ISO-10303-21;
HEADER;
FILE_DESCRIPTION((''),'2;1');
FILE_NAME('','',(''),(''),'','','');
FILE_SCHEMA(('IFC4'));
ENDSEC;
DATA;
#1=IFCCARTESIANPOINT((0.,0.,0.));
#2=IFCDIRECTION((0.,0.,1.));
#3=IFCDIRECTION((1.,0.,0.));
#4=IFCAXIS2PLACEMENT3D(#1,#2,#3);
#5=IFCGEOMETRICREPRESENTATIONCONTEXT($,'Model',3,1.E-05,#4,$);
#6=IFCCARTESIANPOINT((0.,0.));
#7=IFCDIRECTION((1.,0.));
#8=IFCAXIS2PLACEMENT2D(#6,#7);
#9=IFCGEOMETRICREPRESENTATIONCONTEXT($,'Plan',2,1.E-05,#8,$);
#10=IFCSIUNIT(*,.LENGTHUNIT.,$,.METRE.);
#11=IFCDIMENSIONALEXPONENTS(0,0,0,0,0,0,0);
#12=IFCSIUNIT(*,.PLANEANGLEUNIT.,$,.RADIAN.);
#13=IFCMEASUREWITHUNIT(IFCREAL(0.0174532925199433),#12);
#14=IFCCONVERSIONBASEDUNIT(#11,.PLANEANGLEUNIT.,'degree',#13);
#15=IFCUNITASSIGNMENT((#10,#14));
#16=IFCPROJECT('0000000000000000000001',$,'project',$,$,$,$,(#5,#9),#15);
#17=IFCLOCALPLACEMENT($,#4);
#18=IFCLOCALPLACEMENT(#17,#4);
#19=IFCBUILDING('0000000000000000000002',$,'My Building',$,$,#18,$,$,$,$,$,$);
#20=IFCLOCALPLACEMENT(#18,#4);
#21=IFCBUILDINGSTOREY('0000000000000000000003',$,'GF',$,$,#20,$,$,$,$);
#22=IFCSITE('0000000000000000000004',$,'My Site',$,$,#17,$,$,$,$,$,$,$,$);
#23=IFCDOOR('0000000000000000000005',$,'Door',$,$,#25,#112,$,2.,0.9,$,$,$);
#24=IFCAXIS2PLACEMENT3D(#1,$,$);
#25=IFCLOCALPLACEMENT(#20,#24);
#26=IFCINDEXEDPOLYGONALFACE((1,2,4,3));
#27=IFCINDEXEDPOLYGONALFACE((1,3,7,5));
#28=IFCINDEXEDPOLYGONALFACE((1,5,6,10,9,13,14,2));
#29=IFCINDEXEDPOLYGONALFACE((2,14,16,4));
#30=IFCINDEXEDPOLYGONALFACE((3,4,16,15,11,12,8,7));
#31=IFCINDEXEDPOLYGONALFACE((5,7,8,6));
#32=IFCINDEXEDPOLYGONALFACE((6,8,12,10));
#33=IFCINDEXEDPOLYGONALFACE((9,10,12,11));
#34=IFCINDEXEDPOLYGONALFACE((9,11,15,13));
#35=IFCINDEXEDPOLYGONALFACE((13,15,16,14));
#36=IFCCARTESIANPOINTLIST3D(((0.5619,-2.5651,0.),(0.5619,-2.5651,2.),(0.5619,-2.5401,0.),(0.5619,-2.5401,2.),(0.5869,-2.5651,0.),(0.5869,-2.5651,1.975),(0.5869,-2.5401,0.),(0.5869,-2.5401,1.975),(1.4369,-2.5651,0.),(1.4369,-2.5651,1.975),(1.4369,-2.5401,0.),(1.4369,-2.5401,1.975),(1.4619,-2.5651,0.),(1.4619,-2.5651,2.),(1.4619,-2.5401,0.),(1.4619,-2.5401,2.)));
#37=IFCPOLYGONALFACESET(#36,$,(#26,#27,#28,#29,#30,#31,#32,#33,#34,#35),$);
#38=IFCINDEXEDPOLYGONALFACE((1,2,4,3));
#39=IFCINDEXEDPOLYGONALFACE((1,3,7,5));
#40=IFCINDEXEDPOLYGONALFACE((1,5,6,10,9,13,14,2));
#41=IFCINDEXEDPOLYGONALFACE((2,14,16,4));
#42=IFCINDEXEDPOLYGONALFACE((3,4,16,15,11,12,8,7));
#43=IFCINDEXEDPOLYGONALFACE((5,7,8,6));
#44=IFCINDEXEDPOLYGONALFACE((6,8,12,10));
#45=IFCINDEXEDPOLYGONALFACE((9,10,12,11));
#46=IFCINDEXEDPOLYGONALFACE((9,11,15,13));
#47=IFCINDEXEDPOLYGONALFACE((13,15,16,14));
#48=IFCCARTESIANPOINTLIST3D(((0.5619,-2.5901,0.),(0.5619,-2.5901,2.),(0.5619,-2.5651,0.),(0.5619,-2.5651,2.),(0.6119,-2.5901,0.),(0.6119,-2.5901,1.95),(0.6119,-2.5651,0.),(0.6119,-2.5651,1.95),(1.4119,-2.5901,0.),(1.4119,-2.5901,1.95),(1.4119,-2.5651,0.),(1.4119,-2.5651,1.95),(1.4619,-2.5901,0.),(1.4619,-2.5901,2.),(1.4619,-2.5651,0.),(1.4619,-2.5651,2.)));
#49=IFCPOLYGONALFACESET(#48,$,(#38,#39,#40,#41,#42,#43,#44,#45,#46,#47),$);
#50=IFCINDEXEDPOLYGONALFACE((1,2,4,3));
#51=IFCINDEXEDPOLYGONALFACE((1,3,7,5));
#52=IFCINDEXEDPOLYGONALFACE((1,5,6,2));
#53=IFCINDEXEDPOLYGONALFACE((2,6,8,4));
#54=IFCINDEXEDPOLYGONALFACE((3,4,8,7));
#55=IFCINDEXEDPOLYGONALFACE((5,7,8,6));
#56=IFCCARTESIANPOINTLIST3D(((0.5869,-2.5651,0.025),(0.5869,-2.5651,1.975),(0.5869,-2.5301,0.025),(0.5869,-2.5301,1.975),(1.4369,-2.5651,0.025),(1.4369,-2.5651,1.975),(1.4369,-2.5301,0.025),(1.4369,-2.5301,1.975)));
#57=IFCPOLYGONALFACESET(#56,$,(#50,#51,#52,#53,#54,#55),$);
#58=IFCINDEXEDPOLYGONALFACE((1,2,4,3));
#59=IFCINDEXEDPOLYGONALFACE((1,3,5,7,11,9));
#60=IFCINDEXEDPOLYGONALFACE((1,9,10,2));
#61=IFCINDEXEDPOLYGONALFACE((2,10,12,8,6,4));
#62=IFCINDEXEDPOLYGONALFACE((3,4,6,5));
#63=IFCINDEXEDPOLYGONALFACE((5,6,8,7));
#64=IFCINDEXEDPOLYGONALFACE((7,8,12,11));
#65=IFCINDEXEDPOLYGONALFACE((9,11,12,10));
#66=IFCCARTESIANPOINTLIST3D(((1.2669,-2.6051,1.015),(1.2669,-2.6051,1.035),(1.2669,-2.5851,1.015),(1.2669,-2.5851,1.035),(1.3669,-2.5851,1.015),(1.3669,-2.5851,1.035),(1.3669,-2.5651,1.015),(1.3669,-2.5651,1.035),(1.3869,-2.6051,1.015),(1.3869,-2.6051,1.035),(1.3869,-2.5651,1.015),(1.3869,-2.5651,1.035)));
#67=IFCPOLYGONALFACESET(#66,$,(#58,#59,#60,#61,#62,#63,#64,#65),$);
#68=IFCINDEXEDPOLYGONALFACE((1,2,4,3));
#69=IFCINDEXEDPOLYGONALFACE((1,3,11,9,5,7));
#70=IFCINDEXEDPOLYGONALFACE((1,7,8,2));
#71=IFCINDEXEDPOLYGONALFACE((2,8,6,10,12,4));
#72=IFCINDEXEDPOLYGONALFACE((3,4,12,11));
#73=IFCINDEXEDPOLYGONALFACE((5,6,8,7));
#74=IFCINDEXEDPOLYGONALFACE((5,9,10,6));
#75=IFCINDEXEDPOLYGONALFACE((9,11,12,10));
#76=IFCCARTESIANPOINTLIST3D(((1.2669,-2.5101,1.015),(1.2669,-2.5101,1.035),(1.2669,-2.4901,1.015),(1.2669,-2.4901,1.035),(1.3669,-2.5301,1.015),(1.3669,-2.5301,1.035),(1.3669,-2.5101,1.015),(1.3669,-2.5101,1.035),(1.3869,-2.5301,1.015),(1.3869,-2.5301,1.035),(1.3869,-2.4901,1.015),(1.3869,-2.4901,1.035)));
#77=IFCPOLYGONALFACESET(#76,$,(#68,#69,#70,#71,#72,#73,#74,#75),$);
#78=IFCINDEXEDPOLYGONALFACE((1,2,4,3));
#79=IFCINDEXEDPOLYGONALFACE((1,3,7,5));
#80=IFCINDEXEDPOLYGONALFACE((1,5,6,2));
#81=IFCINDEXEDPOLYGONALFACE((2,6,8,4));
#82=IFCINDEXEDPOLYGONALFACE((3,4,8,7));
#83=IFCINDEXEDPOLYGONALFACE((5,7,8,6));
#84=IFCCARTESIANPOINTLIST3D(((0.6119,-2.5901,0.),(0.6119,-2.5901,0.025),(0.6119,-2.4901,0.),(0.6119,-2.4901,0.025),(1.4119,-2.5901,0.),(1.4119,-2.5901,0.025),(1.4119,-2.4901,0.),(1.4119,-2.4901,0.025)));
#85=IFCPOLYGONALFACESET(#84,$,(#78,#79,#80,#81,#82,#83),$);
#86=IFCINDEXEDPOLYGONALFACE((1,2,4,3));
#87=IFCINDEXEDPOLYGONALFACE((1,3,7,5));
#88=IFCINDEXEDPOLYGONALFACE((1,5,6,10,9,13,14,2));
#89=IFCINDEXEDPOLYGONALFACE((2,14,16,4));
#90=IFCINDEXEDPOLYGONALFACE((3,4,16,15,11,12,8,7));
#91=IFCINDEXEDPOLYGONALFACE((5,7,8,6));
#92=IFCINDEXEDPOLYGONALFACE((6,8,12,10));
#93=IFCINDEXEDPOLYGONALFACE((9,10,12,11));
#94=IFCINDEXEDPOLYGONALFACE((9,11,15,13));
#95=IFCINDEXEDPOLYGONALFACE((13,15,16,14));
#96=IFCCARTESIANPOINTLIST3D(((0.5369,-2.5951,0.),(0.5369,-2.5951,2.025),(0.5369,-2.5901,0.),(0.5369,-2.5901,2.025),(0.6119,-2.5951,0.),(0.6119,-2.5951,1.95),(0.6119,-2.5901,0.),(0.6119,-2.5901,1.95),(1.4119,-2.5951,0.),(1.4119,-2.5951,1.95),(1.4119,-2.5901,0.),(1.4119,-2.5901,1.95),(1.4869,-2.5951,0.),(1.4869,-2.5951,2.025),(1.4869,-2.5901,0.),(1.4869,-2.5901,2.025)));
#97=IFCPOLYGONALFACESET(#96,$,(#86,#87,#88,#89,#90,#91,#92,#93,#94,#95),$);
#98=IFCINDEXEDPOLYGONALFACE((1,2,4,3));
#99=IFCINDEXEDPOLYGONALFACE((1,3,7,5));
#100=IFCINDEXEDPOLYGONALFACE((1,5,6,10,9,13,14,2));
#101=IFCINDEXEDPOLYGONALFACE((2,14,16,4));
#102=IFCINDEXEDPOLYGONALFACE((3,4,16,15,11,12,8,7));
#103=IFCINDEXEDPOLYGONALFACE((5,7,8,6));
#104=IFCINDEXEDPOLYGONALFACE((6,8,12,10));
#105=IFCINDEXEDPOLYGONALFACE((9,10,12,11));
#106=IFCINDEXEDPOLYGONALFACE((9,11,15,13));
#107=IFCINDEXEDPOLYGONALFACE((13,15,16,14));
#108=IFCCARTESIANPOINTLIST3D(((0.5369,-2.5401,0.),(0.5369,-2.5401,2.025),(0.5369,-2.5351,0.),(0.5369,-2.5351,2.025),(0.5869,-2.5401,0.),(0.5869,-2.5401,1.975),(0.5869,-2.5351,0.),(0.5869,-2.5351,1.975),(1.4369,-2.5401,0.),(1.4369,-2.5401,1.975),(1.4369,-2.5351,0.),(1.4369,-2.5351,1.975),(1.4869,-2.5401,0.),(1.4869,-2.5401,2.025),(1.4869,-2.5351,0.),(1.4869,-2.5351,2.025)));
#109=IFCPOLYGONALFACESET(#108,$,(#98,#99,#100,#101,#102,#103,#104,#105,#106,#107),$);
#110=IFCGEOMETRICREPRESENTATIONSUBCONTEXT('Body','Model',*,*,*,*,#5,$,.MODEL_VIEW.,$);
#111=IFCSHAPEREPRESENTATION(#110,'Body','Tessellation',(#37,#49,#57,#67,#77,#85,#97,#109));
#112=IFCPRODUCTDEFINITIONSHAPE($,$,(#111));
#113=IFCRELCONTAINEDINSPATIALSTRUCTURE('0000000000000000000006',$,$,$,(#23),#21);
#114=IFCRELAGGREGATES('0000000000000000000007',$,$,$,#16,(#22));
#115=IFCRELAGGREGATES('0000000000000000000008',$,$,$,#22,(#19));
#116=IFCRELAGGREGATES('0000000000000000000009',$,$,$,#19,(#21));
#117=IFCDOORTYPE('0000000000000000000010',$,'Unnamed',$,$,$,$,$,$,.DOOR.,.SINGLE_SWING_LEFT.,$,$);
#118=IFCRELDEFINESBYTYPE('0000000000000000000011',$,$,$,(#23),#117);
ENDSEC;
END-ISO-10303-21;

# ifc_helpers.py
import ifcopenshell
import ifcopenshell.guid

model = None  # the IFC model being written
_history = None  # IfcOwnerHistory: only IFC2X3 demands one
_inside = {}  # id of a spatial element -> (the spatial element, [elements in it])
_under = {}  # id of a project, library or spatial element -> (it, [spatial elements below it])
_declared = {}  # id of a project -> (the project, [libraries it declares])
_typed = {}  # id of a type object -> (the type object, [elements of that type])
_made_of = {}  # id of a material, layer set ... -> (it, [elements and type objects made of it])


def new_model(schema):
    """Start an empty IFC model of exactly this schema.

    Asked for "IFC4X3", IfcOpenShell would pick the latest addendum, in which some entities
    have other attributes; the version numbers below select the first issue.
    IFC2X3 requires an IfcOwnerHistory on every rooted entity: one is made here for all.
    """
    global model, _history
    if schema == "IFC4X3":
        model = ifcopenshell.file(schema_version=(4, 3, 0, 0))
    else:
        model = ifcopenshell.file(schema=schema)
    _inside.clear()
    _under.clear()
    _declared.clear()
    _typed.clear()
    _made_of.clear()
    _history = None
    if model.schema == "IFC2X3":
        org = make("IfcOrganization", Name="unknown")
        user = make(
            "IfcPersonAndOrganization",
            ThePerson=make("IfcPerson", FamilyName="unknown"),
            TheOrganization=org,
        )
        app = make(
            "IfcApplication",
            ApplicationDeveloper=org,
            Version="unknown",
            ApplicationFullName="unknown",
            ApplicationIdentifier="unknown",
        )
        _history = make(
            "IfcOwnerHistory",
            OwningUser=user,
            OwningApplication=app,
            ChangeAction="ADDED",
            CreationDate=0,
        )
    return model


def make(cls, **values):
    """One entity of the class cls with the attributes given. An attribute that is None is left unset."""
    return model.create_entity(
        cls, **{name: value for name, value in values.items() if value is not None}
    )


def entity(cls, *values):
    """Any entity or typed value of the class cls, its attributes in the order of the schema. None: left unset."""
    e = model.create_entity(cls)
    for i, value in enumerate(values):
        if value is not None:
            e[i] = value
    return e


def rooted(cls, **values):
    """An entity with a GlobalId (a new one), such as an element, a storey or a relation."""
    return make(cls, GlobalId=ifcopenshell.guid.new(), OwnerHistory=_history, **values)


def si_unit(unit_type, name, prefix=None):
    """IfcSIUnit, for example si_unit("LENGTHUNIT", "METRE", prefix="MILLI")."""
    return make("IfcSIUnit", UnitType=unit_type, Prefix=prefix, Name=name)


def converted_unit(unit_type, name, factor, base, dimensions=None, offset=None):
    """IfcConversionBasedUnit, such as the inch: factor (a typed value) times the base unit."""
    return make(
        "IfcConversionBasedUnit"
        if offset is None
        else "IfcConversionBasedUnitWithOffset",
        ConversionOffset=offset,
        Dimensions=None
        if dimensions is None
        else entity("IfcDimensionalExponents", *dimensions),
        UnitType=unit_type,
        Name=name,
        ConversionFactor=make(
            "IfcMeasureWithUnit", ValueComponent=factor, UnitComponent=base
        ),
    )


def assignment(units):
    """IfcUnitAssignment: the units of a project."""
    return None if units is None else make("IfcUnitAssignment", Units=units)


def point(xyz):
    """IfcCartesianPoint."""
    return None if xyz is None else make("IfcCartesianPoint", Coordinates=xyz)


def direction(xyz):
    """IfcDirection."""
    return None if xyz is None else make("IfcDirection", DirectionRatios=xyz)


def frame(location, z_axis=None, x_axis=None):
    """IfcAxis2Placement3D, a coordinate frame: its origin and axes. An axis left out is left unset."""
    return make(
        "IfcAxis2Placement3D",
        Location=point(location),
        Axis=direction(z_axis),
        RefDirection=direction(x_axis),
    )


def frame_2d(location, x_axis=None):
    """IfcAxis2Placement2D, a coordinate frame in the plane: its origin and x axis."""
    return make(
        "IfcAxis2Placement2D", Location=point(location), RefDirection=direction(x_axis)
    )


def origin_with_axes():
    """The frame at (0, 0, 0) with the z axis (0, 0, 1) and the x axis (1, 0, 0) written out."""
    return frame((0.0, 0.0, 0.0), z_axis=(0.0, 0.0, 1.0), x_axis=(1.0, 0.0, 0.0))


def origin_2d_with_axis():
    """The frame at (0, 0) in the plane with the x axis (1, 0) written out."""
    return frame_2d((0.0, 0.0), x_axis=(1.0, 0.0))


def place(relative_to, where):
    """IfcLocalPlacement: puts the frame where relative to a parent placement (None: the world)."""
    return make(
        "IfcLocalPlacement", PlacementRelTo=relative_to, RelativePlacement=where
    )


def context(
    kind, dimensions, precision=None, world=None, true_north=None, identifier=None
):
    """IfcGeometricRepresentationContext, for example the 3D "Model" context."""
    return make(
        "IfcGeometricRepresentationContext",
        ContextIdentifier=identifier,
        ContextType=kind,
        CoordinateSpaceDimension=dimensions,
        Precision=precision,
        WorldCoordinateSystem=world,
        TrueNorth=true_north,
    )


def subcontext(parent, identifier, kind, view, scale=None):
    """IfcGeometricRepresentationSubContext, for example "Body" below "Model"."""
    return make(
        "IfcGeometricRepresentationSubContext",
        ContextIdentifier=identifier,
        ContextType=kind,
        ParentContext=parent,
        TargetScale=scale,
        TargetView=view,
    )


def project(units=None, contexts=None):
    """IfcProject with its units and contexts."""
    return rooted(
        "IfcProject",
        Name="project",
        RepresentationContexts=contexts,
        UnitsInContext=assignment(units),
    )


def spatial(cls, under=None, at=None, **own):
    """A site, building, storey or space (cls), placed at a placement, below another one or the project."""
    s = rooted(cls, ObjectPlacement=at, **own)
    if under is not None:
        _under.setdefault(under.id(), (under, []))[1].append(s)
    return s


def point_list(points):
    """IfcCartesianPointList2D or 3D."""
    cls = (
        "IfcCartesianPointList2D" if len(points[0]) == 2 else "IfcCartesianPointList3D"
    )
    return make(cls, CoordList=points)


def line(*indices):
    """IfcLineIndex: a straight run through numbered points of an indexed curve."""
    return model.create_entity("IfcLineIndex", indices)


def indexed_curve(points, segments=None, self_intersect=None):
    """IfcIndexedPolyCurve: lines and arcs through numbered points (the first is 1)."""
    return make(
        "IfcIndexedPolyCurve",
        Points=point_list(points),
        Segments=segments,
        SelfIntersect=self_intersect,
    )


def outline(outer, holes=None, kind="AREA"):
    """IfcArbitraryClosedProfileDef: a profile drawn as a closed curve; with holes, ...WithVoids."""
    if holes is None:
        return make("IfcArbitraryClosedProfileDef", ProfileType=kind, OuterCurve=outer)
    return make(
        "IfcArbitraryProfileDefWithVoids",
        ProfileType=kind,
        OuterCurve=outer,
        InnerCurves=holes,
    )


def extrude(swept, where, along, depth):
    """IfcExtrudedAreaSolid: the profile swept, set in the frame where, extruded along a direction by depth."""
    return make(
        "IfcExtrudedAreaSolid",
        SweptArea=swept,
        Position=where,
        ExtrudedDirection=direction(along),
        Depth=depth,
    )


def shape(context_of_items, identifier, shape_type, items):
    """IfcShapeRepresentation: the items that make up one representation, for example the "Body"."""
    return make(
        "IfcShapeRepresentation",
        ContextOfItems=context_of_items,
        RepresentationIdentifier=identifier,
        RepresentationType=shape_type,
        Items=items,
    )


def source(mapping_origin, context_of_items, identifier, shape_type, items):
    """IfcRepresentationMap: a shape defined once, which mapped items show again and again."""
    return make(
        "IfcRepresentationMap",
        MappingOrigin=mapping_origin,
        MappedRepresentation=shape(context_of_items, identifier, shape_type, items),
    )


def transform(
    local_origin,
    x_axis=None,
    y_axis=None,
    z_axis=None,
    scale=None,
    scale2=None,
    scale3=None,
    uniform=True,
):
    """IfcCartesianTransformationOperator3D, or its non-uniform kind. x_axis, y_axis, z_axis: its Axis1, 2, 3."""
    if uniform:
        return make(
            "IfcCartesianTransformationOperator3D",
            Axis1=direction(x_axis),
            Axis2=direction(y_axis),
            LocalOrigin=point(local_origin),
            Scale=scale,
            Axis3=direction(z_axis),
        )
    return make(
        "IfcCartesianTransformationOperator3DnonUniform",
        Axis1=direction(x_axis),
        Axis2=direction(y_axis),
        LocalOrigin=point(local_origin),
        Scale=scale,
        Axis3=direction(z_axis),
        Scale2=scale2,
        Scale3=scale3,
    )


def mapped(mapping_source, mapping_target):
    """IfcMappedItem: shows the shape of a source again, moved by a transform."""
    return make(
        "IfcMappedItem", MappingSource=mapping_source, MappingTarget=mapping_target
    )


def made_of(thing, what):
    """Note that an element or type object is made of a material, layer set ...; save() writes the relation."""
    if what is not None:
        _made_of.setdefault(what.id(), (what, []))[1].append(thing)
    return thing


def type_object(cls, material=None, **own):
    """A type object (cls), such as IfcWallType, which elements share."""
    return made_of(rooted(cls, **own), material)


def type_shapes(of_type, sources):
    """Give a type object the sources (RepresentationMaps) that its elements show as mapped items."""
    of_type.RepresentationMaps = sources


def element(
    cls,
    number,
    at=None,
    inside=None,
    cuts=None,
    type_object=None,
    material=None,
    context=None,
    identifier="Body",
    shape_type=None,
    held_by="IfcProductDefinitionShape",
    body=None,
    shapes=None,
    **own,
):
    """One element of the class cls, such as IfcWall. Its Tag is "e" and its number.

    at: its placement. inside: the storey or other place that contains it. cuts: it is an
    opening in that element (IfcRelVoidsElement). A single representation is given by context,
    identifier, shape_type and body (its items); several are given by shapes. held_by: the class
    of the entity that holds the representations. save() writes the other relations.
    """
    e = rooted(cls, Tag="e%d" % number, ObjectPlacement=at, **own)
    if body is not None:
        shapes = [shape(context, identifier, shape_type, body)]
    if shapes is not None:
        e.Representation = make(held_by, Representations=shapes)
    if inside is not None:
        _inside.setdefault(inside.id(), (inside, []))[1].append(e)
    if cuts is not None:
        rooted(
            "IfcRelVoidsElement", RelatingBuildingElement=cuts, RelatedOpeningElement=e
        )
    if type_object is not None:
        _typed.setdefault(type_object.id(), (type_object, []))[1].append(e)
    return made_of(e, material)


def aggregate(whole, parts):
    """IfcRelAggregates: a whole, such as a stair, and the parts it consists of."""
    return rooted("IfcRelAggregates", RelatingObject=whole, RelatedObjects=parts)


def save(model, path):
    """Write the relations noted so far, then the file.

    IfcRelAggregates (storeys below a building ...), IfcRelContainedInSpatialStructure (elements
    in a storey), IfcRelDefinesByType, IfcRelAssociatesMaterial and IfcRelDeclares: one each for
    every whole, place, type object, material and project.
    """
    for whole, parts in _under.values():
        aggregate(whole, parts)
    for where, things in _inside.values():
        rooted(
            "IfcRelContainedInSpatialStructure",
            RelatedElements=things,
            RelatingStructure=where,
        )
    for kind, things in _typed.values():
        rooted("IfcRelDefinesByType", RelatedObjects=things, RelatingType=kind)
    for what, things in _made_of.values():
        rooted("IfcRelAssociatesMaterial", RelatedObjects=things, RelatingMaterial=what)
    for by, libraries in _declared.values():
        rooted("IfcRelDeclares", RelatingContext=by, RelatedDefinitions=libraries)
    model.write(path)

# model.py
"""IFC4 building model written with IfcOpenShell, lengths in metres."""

from ifc_helpers import new_model, entity, si_unit, converted_unit, frame, origin_with_axes, origin_2d_with_axis, place, context, subcontext, project, spatial, line, indexed_curve, outline, extrude, shape, source, transform, mapped, type_object, type_shapes, element, save


model = new_model("IFC4")

# Units and contexts
model_context = context("Model", 3, precision=1e-05, world=origin_with_axes())
plan_context = context("Plan", 2, precision=1e-05, world=origin_2d_with_axis())
body_context_1 = subcontext(model_context, "Body", "Model", "MODEL_VIEW")
body_context_2 = subcontext(plan_context, "Body", "Plan", "PLAN_VIEW")
ifc_project = project(units=[si_unit("LENGTHUNIT", "METRE"), converted_unit("PLANEANGLEUNIT", "degree", entity("IfcReal", 0.0174532925199433), si_unit("PLANEANGLEUNIT", "RADIAN"), dimensions=[0, 0, 0, 0, 0, 0, 0])], contexts=[model_context, plan_context])

# Site, building, storey
site_placement = place(None, origin_with_axes())
site = spatial("IfcSite", under=ifc_project, at=site_placement, Name="My Site")
building_placement = place(site_placement, origin_with_axes())
building = spatial("IfcBuilding", under=site, at=building_placement, Name="My Building")
storey_placement = place(building_placement, origin_with_axes())
storey = spatial("IfcBuildingStorey", under=building, at=storey_placement, Name="GF")

# Shared definitions
door_type = type_object("IfcDoorType", Name="Unnamed", OperationType="SINGLE_SWING_LEFT", PredefinedType="DOOR")
shared_shape_1 = source(origin_with_axes(), body_context_1, "Body", "SweptSolid", [
    extrude(outline(indexed_curve([(0.0, 0.0), (0.0, 2.0), (0.9, 2.0), (0.9, 0.0), (0.875, 0.0), (0.875, 1.975), (0.025, 1.975), (0.025, 0.0)], segments=[line(1, 2, 3, 4, 5, 6, 7, 8, 1)])), frame((0.0, 0.025, 0.0), z_axis=(0.0, -1.0, 0.0), x_axis=(1.0, 0.0, 0.0)), (0.0, 0.0, -1.0), 0.025),
    extrude(outline(indexed_curve([(0.0, 0.0), (0.0, 2.0), (0.9, 2.0), (0.9, 0.0), (0.85, 0.0), (0.85, 1.95), (0.05, 1.95), (0.05, 0.0)], segments=[line(1, 2, 3, 4, 5, 6, 7, 8, 1)])), frame((0.0, 0.0, 0.0), z_axis=(0.0, -1.0, 0.0), x_axis=(1.0, 0.0, 0.0)), (0.0, 0.0, -1.0), 0.025),
    extrude(outline(indexed_curve([(0.0, 0.0), (0.85, 0.0), (0.85, 0.035), (0.0, 0.035)], segments=[line(1, 2, 3, 4, 1)])), frame((0.025, 0.025, 0.025), z_axis=(0.0, 0.0, 1.0), x_axis=(1.0, 0.0, 0.0)), (0.0, 0.0, 1.0), 1.95),
    extrude(outline(indexed_curve([(0.0, 0.0), (0.0, -0.04), (-0.12, -0.04), (-0.12, -0.02), (-0.02, -0.02), (-0.02, 0.0)], segments=[line(1, 2, 3, 4, 5, 6, 1)])), frame((0.825, 0.025, 1.015), z_axis=(0.0, 0.0, 1.0), x_axis=(1.0, 0.0, 0.0)), (0.0, 0.0, 1.0), 0.02),
    extrude(outline(indexed_curve([(0.0, 0.0), (0.0, 0.04), (-0.12, 0.04), (-0.12, 0.02), (-0.02, 0.02), (-0.02, 0.0)], segments=[line(1, 2, 3, 4, 5, 6, 1)])), frame((0.825, 0.06, 1.015), z_axis=(0.0, 0.0, 1.0), x_axis=(1.0, 0.0, 0.0)), (0.0, 0.0, 1.0), 0.02),
    extrude(outline(indexed_curve([(0.0, 0.0), (0.8, 0.0), (0.8, 0.1), (0.0, 0.1)], segments=[line(1, 2, 3, 4, 1)])), frame((0.05, 0.0, 0.0), z_axis=(0.0, 0.0, 1.0), x_axis=(1.0, 0.0, 0.0)), (0.0, 0.0, 1.0), 0.025),
    extrude(outline(indexed_curve([(0.0, 0.0), (0.0, 2.025), (0.95, 2.025), (0.95, 0.0), (0.875, 0.0), (0.875, 1.95), (0.075, 1.95), (0.075, 0.0)], segments=[line(1, 2, 3, 4, 5, 6, 7, 8, 1)])), frame((-0.025, -0.005, 0.0), z_axis=(0.0, -1.0, 0.0), x_axis=(1.0, 0.0, 0.0)), (0.0, 0.0, -1.0), 0.005),
    extrude(outline(indexed_curve([(0.0, 0.0), (0.0, 2.025), (0.95, 2.025), (0.95, 0.0), (0.9, 0.0), (0.9, 1.975), (0.05, 1.975), (0.05, 0.0)], segments=[line(1, 2, 3, 4, 5, 6, 7, 8, 1)])), frame((-0.025, 0.05, 0.0), z_axis=(0.0, -1.0, 0.0), x_axis=(1.0, 0.0, 0.0)), (0.0, 0.0, -1.0), 0.005),
])
shared_shape_2 = source(origin_with_axes(), body_context_2, "Body", "Curve2D", [
    entity("IfcIndexedPolyCurve", entity("IfcCartesianPointList2D", [[0.0, 0.0], [0.0, 0.05], [0.025, 0.05], [0.025, 0.025], [0.05, 0.025], [0.05, 0.0]]), [entity("IfcLineIndex", [1, 2, 3, 4, 5, 6, 1])]),
    entity("IfcIndexedPolyCurve", entity("IfcCartesianPointList2D", [[0.9, 0.0], [0.9, 0.05], [0.875, 0.05], [0.875, 0.025], [0.85, 0.025], [0.85, 0.0]]), [entity("IfcLineIndex", [1, 2, 3, 4, 5, 6, 1])]),
    entity("IfcTrimmedCurve", entity("IfcEllipse", entity("IfcAxis2Placement2D", entity("IfcCartesianPoint", [0.06, 0.05]), entity("IfcDirection", [1.0, 0.0])), 0.815, 0.85), [entity("IfcCartesianPoint", [0.875, 0.05])], [entity("IfcCartesianPoint", [0.06, 0.9])], True, "CARTESIAN"),
    entity("IfcIndexedPolyCurve", entity("IfcCartesianPointList2D", [[0.025, 0.05], [0.06, 0.05], [0.06, 0.9], [0.025, 0.9]]), [entity("IfcLineIndex", [1, 2, 3, 4, 1])]),
])
type_shapes(door_type, [shared_shape_1, shared_shape_2])

# Door
door_1_placement = place(storey_placement, frame((0.5619, -2.5901, 0.0), z_axis=(0.0, 0.0, 1.0), x_axis=(1.0, 0.0, 0.0)))
element("IfcDoor", 1, at=door_1_placement, inside=storey, type_object=door_type, Name="Door", OverallHeight=2.0, OverallWidth=0.9, shapes=[
    shape(body_context_1, "Body", "MappedRepresentation", [mapped(shared_shape_1, transform((0.0, 0.0, 0.0), x_axis=(1.0, 0.0, 0.0), y_axis=(0.0, 1.0, 0.0), z_axis=(0.0, 0.0, 1.0), scale=1.0))]),
    shape(body_context_2, "Body", "MappedRepresentation", [mapped(shared_shape_2, transform((0.0, 0.0, 0.0), x_axis=(1.0, 0.0, 0.0), y_axis=(0.0, 1.0, 0.0), z_axis=(0.0, 0.0, 1.0), scale=1.0))]),
])

save(model, "model.ifc")
